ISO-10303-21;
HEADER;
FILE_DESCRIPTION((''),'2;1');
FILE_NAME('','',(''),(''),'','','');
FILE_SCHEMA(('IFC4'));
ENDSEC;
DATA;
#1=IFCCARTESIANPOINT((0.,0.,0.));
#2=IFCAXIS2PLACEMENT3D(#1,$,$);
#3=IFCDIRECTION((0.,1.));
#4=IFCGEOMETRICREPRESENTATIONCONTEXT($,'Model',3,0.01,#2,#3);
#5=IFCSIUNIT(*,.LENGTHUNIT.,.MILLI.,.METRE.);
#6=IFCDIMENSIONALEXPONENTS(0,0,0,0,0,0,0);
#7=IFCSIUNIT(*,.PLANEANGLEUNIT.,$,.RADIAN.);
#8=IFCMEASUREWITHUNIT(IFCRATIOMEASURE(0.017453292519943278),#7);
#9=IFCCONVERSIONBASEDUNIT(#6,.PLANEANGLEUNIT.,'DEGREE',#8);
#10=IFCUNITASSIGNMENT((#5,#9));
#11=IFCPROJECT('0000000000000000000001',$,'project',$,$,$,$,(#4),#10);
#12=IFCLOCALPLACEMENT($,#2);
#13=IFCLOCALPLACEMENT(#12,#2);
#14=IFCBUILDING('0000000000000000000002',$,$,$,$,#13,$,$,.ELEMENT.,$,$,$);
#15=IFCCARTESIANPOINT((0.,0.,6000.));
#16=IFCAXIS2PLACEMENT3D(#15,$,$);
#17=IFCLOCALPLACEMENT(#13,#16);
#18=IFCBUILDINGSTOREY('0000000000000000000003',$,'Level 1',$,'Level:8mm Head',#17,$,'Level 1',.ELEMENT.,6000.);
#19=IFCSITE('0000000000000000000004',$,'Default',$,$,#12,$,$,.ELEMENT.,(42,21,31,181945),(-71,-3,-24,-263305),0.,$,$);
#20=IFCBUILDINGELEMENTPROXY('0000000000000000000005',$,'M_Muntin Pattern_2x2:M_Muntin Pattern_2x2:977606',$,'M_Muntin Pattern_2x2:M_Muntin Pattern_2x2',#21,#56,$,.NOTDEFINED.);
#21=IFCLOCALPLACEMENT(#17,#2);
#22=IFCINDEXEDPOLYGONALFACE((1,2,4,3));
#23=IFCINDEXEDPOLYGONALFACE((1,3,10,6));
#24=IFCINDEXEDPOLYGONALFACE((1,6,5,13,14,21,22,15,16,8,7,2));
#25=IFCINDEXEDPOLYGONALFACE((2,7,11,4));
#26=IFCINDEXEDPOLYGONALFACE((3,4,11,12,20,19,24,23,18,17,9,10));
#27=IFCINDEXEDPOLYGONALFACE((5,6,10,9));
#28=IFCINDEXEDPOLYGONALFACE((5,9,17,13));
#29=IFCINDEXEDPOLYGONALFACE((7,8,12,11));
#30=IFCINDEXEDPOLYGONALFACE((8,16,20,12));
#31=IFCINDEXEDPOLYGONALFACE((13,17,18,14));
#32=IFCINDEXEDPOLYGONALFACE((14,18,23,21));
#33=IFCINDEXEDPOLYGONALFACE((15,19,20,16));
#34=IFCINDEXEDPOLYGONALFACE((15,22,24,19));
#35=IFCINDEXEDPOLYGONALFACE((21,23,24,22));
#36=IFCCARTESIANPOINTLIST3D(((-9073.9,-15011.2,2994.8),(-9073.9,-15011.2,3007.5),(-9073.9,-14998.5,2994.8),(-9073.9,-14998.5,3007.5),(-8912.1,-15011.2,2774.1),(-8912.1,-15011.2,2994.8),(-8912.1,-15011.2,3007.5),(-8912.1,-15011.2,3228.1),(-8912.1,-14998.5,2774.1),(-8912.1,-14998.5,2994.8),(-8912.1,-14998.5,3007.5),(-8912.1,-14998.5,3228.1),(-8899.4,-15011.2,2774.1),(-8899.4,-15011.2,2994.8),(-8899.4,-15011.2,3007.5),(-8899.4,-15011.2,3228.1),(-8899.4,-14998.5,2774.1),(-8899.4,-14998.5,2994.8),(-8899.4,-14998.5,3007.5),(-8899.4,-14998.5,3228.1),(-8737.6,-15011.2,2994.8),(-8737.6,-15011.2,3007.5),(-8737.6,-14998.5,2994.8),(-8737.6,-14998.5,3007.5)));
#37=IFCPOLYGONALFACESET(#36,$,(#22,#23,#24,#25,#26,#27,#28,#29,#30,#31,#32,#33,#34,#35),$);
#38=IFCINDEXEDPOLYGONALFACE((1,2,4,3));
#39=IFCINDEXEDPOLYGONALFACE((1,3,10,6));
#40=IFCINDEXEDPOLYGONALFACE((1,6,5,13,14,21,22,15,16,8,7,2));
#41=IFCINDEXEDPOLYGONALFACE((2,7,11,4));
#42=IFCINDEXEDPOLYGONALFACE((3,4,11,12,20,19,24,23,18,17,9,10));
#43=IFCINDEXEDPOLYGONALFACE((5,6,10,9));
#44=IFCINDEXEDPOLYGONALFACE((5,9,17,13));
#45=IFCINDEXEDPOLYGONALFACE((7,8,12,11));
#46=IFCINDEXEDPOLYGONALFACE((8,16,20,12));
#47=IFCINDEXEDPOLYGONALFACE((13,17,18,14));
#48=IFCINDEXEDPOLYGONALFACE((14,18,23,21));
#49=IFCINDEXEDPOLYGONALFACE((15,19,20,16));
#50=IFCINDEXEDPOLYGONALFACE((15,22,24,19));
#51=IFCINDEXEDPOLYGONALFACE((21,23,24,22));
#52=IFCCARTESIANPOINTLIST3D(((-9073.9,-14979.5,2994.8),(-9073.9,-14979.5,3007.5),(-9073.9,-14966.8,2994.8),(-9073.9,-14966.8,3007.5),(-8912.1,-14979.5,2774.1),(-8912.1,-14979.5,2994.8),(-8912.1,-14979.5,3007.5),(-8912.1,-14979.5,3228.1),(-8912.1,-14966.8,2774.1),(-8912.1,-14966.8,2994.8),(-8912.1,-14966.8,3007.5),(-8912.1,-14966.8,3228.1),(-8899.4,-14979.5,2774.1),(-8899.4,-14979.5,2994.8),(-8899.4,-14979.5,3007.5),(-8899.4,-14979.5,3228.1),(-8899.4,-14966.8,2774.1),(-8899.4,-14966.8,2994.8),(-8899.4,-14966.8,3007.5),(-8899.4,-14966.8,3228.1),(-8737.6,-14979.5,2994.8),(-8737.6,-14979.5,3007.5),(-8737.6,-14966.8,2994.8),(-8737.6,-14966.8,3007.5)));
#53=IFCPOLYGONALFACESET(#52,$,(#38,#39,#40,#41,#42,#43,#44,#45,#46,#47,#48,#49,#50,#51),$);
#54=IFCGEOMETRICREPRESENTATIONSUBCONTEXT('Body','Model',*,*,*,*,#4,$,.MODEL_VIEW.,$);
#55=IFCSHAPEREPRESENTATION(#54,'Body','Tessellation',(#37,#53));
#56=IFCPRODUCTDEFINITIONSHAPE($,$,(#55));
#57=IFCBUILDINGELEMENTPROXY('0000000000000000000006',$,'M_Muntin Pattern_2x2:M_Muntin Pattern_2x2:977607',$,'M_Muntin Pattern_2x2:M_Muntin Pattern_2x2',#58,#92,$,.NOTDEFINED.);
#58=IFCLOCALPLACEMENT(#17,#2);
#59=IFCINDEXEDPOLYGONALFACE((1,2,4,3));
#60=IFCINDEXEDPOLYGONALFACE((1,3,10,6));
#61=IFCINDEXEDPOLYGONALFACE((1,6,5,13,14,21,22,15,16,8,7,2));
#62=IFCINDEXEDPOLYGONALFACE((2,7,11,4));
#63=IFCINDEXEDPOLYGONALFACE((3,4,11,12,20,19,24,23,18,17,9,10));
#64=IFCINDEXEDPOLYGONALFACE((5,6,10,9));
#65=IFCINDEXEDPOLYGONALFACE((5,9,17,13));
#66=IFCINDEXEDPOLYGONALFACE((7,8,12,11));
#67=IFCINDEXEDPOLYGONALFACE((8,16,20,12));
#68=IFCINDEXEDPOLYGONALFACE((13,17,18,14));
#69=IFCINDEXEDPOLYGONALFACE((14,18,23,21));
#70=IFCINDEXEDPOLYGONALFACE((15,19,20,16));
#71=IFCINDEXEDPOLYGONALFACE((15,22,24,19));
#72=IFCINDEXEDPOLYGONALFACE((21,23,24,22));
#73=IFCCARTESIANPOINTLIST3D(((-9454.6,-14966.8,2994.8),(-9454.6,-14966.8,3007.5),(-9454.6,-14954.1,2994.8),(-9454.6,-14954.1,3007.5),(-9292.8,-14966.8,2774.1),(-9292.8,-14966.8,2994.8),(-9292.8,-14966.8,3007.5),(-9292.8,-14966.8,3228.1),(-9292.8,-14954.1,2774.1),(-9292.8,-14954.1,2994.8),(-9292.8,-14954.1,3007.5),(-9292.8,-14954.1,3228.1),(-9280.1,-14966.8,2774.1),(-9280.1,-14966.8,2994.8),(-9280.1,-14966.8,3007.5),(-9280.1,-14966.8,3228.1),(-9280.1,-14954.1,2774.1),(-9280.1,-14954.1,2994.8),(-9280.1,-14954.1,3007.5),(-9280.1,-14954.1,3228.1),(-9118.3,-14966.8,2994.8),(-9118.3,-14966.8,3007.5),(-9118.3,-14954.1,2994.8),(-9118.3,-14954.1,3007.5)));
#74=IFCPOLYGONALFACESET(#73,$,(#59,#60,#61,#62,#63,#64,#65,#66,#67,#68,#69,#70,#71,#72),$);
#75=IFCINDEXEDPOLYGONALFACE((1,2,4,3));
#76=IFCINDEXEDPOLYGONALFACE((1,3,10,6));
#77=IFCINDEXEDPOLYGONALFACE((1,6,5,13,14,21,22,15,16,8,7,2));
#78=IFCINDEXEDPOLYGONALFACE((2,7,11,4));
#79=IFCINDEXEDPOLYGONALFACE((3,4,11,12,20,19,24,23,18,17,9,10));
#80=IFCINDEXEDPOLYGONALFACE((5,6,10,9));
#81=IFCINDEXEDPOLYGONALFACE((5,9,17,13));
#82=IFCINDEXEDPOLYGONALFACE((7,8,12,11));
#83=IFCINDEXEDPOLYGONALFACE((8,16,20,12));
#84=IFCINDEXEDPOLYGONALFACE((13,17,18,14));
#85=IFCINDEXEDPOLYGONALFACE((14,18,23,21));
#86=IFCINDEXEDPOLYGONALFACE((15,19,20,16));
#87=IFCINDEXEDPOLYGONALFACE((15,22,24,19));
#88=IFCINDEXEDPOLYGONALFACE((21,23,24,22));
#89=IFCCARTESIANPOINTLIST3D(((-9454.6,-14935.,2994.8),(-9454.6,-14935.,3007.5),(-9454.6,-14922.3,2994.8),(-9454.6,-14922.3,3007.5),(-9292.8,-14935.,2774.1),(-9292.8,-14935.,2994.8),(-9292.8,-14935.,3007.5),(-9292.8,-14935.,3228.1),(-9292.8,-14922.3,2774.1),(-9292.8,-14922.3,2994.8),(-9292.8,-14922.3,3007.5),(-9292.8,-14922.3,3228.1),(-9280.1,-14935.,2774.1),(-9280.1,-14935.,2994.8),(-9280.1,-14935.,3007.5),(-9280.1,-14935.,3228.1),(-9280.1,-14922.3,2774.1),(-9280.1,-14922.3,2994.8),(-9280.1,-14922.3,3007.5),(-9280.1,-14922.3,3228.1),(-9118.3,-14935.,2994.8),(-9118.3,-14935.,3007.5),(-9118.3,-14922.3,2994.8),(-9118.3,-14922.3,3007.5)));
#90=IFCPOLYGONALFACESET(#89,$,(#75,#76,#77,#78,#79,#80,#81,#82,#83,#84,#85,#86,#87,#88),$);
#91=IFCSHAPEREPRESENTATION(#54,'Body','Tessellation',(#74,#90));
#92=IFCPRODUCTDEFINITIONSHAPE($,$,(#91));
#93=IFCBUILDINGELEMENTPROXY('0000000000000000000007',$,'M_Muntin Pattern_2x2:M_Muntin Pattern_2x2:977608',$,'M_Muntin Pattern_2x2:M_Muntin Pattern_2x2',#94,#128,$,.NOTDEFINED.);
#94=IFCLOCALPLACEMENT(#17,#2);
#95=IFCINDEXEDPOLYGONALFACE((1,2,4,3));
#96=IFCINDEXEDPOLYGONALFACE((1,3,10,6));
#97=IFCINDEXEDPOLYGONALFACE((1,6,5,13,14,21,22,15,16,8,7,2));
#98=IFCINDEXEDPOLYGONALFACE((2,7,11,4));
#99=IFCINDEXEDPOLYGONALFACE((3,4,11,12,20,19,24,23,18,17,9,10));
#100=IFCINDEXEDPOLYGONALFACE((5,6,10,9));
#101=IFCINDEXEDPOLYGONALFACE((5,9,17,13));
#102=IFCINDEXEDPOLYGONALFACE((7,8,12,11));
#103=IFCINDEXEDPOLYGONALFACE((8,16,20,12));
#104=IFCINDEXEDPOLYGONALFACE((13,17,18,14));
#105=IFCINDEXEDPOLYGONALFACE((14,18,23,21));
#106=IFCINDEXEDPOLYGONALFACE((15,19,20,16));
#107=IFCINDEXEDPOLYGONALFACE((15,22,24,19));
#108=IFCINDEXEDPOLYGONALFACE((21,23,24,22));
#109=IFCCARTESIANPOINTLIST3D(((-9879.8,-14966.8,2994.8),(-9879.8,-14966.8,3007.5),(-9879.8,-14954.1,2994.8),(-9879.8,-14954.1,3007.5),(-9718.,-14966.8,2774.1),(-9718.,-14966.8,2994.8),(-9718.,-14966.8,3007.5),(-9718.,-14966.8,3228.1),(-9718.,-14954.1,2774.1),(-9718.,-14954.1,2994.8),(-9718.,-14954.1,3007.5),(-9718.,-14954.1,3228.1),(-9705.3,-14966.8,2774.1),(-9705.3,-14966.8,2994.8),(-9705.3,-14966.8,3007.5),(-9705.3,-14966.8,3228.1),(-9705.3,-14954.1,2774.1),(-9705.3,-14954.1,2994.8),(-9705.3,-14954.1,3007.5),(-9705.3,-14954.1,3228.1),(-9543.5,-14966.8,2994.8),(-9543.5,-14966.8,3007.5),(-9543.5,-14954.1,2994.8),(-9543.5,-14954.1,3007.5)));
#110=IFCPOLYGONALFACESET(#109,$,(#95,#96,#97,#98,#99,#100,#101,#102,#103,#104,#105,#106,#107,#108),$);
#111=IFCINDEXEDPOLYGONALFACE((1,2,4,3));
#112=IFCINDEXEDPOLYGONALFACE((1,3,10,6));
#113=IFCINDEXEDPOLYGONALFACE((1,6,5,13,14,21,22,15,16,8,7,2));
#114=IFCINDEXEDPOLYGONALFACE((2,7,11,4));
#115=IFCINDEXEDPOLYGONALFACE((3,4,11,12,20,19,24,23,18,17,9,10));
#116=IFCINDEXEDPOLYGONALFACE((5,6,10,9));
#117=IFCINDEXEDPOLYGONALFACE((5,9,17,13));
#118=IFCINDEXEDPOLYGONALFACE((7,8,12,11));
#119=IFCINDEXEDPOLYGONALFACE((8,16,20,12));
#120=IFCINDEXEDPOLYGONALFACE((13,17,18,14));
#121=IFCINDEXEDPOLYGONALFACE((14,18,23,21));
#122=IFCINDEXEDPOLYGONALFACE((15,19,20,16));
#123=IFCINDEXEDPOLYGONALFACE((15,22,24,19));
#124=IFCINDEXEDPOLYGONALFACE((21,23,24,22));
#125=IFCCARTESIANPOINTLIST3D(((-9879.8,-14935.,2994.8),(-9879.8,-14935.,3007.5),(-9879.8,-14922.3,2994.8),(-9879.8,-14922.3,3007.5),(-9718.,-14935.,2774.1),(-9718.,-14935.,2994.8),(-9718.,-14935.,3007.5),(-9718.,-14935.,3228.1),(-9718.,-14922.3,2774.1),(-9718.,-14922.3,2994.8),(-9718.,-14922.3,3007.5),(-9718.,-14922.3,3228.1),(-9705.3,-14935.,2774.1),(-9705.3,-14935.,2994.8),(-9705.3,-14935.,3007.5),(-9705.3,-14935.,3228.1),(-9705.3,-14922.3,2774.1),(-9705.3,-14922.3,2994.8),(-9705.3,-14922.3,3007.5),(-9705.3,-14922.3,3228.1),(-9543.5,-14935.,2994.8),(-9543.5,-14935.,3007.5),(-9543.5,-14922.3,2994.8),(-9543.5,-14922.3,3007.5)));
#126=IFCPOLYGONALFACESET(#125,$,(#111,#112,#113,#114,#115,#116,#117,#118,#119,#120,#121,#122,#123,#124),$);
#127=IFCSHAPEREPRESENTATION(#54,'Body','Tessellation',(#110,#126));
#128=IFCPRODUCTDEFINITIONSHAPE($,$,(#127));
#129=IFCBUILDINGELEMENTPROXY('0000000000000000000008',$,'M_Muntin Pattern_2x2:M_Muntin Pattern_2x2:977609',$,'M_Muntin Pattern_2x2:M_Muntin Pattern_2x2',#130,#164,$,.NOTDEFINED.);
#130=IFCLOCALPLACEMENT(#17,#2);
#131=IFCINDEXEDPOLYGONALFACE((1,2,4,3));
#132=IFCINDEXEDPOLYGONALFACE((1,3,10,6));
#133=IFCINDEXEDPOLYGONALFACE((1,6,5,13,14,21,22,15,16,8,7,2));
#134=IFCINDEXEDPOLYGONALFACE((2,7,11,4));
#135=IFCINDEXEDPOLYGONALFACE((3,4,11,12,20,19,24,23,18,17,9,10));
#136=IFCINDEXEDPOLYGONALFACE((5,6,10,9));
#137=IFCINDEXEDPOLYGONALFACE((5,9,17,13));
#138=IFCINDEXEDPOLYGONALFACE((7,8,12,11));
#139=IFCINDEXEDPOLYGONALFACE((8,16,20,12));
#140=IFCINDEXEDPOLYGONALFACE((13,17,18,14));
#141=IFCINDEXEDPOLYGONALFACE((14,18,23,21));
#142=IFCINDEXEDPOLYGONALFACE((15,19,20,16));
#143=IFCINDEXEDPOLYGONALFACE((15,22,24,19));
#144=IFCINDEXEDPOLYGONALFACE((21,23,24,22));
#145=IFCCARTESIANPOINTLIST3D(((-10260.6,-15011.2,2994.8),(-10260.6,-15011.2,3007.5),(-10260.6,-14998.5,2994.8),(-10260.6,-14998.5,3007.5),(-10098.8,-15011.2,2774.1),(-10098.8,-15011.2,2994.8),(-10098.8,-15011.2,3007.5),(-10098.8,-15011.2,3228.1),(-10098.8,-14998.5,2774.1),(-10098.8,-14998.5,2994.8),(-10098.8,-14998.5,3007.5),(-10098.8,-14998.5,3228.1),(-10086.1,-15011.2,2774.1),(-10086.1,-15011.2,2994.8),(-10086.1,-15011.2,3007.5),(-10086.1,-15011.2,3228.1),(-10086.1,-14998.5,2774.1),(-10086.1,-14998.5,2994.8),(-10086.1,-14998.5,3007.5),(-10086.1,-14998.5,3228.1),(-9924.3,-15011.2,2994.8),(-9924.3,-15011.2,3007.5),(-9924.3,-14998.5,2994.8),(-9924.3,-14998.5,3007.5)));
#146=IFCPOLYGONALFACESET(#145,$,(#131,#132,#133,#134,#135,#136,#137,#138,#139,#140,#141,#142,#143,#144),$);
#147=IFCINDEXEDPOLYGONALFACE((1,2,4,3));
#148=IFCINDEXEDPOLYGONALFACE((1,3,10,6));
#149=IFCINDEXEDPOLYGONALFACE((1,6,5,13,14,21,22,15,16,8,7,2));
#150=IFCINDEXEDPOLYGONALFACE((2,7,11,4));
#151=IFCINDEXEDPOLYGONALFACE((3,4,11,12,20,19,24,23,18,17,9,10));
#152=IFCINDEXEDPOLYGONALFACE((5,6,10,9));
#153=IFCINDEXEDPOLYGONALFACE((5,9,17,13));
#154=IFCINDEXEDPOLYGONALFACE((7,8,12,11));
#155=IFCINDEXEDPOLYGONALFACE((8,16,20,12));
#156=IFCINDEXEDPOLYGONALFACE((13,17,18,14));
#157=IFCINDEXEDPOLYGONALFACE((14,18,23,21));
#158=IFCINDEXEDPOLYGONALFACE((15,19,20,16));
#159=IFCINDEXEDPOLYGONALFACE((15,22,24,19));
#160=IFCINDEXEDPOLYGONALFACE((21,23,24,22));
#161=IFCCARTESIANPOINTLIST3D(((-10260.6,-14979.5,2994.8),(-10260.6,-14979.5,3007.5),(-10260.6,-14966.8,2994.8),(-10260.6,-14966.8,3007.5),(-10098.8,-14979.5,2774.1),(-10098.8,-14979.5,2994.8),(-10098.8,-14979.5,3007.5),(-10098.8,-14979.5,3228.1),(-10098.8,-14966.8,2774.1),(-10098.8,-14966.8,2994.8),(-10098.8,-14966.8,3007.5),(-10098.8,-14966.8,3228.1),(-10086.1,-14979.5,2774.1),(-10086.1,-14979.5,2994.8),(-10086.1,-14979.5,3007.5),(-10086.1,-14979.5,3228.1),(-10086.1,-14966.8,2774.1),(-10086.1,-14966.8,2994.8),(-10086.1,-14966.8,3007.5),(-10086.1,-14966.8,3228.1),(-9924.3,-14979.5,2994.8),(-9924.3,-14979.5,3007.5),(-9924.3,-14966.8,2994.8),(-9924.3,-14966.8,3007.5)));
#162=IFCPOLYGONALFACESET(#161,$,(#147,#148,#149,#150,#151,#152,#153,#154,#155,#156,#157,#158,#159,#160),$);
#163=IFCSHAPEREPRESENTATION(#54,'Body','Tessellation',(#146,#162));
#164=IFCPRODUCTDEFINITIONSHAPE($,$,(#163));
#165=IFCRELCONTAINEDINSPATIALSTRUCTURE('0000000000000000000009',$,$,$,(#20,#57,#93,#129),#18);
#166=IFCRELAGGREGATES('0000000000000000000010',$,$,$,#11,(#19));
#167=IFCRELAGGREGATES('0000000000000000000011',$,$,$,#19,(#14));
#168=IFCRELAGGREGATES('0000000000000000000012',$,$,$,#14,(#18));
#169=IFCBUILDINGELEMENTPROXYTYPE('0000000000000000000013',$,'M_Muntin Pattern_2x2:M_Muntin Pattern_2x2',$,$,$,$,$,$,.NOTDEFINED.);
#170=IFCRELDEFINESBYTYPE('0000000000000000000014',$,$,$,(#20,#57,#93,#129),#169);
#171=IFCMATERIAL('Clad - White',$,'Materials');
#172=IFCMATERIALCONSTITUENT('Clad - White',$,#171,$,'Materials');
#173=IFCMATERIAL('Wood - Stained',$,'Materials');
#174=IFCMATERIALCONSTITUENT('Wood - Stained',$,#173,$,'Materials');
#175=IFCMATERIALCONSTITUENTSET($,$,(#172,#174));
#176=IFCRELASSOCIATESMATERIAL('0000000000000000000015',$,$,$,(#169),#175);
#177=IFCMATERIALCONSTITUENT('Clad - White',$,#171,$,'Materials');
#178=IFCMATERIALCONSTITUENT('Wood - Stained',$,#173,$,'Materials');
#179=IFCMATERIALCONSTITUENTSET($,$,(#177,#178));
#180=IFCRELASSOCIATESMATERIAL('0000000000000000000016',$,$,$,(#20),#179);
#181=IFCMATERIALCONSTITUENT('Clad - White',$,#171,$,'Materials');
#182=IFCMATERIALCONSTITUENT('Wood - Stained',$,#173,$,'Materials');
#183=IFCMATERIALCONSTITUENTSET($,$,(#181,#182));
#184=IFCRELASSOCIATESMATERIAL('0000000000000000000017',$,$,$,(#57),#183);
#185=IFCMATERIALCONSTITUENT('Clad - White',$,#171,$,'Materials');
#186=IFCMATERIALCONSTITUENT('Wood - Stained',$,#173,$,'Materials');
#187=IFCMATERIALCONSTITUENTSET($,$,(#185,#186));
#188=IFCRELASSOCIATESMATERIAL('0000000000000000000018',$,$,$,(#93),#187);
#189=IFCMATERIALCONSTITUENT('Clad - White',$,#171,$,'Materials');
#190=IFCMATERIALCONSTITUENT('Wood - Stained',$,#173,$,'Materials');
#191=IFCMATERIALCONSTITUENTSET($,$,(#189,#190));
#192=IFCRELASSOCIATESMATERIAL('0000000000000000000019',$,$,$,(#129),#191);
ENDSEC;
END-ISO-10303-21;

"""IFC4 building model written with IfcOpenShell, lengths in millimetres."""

from ifc_helpers import new_model, entity, si_unit, converted_unit, direction, frame, origin, place, context, subcontext, project, spatial, indexed_curve, outline, extrude, source, transform, mapped, material, constituent, constituent_set, type_object, type_shapes, element, save


model = new_model("IFC4")

# Units and contexts
model_context = context("Model", 3, precision=0.01, world=origin(), true_north=direction((0.0, 1.0)))
body_context = subcontext(model_context, "Body", "Model", "MODEL_VIEW")
ifc_project = project(units=[si_unit("LENGTHUNIT", "METRE", prefix="MILLI"), converted_unit("PLANEANGLEUNIT", "DEGREE", entity("IfcRatioMeasure", 0.017453292519943278), si_unit("PLANEANGLEUNIT", "RADIAN"), dimensions=[0, 0, 0, 0, 0, 0, 0])], contexts=[model_context])

# Site, building, storey
site_placement = place(None, origin())
site = spatial("IfcSite", under=ifc_project, at=site_placement, Name="Default", CompositionType="ELEMENT", RefLatitude=(42, 21, 31, 181945), RefLongitude=(-71, -3, -24, -263305), RefElevation=0.0)
building_placement = place(site_placement, origin())
building = spatial("IfcBuilding", under=site, at=building_placement, CompositionType="ELEMENT")
storey_placement = place(building_placement, frame((0.0, 0.0, 6000.0)))
storey = spatial("IfcBuildingStorey", under=building, at=storey_placement, Name="Level 1", ObjectType="Level:8mm Head", LongName="Level 1", CompositionType="ELEMENT", Elevation=6000.0)

# Building element proxies
ifc_material_1 = material(Name="Clad - White", Category="Materials")
ifc_material_2 = material(Name="Wood - Stained", Category="Materials")
ifc_constituent_1 = constituent(ifc_material_1, Name="Clad - White", Category="Materials")
ifc_constituent_2 = constituent(ifc_material_2, Name="Wood - Stained", Category="Materials")
ifc_constituent_set_1 = constituent_set(constituents=[ifc_constituent_1, ifc_constituent_2])
building_element_proxy_type_1 = type_object("IfcBuildingElementProxyType", Name="M_Muntin Pattern_2x2:M_Muntin Pattern_2x2", PredefinedType="NOTDEFINED", material=ifc_constituent_set_1)
shared_shape_1 = source(origin(), body_context, "Body", "SweptSolid", [
    extrude(outline(indexed_curve([(6.4, -6.4), (227.0, -6.4), (227.0, 6.3), (6.4, 6.3), (6.4, 168.2), (-6.3, 168.2), (-6.3, 6.3), (-227.0, 6.3), (-227.0, -6.4), (-6.3, -6.4), (-6.3, -168.1), (6.4, -168.1), (6.4, -6.4)], self_intersect=False)), frame((0.0, 9.5, 227.0), z_axis=(0.0, 1.0, 0.0), x_axis=(0.0, 0.0, 1.0)), (0.0, 0.0, 1.0), 12.7),
    extrude(outline(indexed_curve([(6.4, -6.4), (227.0, -6.4), (227.0, 6.3), (6.4, 6.3), (6.4, 168.2), (-6.3, 168.2), (-6.3, 6.3), (-227.0, 6.3), (-227.0, -6.4), (-6.3, -6.4), (-6.3, -168.1), (6.4, -168.1), (6.4, -6.4)], self_intersect=False)), frame((0.0, -22.2, 227.0), z_axis=(0.0, 1.0, 0.0), x_axis=(0.0, 0.0, 1.0)), (0.0, 0.0, 1.0), 12.7),
])
type_shapes(building_element_proxy_type_1, [shared_shape_1])
ifc_constituent_3 = constituent(ifc_material_1, Name="Clad - White", Category="Materials")
ifc_constituent_4 = constituent(ifc_material_2, Name="Wood - Stained", Category="Materials")
ifc_constituent_set_2 = constituent_set(constituents=[ifc_constituent_3, ifc_constituent_4])
proxy_1_placement = place(storey_placement, frame((-8905.7, -14989.0, 2774.1), z_axis=(0.0, 0.0, 1.0), x_axis=(-1.0, 0.0, 0.0)))
element("IfcBuildingElementProxy", 1, at=proxy_1_placement, inside=storey, type_object=building_element_proxy_type_1, material=ifc_constituent_set_2, Name="M_Muntin Pattern_2x2:M_Muntin Pattern_2x2:977606", ObjectType="M_Muntin Pattern_2x2:M_Muntin Pattern_2x2", PredefinedType="NOTDEFINED", context=body_context, shape_type="MappedRepresentation", body=[
    mapped(shared_shape_1, transform((0.0, 0.0, 0.0), scale=1.0)),
])
ifc_constituent_5 = constituent(ifc_material_1, Name="Clad - White", Category="Materials")
ifc_constituent_6 = constituent(ifc_material_2, Name="Wood - Stained", Category="Materials")
ifc_constituent_set_3 = constituent_set(constituents=[ifc_constituent_5, ifc_constituent_6])
proxy_2_placement = place(storey_placement, frame((-9286.5, -14944.6, 2774.1), z_axis=(0.0, 0.0, 1.0), x_axis=(-1.0, 0.0, 0.0)))
element("IfcBuildingElementProxy", 2, at=proxy_2_placement, inside=storey, type_object=building_element_proxy_type_1, material=ifc_constituent_set_3, Name="M_Muntin Pattern_2x2:M_Muntin Pattern_2x2:977607", ObjectType="M_Muntin Pattern_2x2:M_Muntin Pattern_2x2", PredefinedType="NOTDEFINED", context=body_context, shape_type="MappedRepresentation", body=[
    mapped(shared_shape_1, transform((0.0, 0.0, 0.0), scale=1.0)),
])
ifc_constituent_7 = constituent(ifc_material_1, Name="Clad - White", Category="Materials")
ifc_constituent_8 = constituent(ifc_material_2, Name="Wood - Stained", Category="Materials")
ifc_constituent_set_4 = constituent_set(constituents=[ifc_constituent_7, ifc_constituent_8])
proxy_3_placement = place(storey_placement, frame((-9711.7, -14944.6, 2774.1), z_axis=(0.0, 0.0, 1.0), x_axis=(-1.0, 0.0, 0.0)))
element("IfcBuildingElementProxy", 3, at=proxy_3_placement, inside=storey, type_object=building_element_proxy_type_1, material=ifc_constituent_set_4, Name="M_Muntin Pattern_2x2:M_Muntin Pattern_2x2:977608", ObjectType="M_Muntin Pattern_2x2:M_Muntin Pattern_2x2", PredefinedType="NOTDEFINED", context=body_context, shape_type="MappedRepresentation", body=[
    mapped(shared_shape_1, transform((0.0, 0.0, 0.0), scale=1.0)),
])
ifc_constituent_9 = constituent(ifc_material_1, Name="Clad - White", Category="Materials")
ifc_constituent_10 = constituent(ifc_material_2, Name="Wood - Stained", Category="Materials")
ifc_constituent_set_5 = constituent_set(constituents=[ifc_constituent_9, ifc_constituent_10])
proxy_4_placement = place(storey_placement, frame((-10092.4, -14989.0, 2774.1), z_axis=(0.0, 0.0, 1.0), x_axis=(-1.0, 0.0, 0.0)))
element("IfcBuildingElementProxy", 4, at=proxy_4_placement, inside=storey, type_object=building_element_proxy_type_1, material=ifc_constituent_set_5, Name="M_Muntin Pattern_2x2:M_Muntin Pattern_2x2:977609", ObjectType="M_Muntin Pattern_2x2:M_Muntin Pattern_2x2", PredefinedType="NOTDEFINED", context=body_context, shape_type="MappedRepresentation", body=[
    mapped(shared_shape_1, transform((0.0, 0.0, 0.0), scale=1.0)),
])

save(model, "model.ifc")
